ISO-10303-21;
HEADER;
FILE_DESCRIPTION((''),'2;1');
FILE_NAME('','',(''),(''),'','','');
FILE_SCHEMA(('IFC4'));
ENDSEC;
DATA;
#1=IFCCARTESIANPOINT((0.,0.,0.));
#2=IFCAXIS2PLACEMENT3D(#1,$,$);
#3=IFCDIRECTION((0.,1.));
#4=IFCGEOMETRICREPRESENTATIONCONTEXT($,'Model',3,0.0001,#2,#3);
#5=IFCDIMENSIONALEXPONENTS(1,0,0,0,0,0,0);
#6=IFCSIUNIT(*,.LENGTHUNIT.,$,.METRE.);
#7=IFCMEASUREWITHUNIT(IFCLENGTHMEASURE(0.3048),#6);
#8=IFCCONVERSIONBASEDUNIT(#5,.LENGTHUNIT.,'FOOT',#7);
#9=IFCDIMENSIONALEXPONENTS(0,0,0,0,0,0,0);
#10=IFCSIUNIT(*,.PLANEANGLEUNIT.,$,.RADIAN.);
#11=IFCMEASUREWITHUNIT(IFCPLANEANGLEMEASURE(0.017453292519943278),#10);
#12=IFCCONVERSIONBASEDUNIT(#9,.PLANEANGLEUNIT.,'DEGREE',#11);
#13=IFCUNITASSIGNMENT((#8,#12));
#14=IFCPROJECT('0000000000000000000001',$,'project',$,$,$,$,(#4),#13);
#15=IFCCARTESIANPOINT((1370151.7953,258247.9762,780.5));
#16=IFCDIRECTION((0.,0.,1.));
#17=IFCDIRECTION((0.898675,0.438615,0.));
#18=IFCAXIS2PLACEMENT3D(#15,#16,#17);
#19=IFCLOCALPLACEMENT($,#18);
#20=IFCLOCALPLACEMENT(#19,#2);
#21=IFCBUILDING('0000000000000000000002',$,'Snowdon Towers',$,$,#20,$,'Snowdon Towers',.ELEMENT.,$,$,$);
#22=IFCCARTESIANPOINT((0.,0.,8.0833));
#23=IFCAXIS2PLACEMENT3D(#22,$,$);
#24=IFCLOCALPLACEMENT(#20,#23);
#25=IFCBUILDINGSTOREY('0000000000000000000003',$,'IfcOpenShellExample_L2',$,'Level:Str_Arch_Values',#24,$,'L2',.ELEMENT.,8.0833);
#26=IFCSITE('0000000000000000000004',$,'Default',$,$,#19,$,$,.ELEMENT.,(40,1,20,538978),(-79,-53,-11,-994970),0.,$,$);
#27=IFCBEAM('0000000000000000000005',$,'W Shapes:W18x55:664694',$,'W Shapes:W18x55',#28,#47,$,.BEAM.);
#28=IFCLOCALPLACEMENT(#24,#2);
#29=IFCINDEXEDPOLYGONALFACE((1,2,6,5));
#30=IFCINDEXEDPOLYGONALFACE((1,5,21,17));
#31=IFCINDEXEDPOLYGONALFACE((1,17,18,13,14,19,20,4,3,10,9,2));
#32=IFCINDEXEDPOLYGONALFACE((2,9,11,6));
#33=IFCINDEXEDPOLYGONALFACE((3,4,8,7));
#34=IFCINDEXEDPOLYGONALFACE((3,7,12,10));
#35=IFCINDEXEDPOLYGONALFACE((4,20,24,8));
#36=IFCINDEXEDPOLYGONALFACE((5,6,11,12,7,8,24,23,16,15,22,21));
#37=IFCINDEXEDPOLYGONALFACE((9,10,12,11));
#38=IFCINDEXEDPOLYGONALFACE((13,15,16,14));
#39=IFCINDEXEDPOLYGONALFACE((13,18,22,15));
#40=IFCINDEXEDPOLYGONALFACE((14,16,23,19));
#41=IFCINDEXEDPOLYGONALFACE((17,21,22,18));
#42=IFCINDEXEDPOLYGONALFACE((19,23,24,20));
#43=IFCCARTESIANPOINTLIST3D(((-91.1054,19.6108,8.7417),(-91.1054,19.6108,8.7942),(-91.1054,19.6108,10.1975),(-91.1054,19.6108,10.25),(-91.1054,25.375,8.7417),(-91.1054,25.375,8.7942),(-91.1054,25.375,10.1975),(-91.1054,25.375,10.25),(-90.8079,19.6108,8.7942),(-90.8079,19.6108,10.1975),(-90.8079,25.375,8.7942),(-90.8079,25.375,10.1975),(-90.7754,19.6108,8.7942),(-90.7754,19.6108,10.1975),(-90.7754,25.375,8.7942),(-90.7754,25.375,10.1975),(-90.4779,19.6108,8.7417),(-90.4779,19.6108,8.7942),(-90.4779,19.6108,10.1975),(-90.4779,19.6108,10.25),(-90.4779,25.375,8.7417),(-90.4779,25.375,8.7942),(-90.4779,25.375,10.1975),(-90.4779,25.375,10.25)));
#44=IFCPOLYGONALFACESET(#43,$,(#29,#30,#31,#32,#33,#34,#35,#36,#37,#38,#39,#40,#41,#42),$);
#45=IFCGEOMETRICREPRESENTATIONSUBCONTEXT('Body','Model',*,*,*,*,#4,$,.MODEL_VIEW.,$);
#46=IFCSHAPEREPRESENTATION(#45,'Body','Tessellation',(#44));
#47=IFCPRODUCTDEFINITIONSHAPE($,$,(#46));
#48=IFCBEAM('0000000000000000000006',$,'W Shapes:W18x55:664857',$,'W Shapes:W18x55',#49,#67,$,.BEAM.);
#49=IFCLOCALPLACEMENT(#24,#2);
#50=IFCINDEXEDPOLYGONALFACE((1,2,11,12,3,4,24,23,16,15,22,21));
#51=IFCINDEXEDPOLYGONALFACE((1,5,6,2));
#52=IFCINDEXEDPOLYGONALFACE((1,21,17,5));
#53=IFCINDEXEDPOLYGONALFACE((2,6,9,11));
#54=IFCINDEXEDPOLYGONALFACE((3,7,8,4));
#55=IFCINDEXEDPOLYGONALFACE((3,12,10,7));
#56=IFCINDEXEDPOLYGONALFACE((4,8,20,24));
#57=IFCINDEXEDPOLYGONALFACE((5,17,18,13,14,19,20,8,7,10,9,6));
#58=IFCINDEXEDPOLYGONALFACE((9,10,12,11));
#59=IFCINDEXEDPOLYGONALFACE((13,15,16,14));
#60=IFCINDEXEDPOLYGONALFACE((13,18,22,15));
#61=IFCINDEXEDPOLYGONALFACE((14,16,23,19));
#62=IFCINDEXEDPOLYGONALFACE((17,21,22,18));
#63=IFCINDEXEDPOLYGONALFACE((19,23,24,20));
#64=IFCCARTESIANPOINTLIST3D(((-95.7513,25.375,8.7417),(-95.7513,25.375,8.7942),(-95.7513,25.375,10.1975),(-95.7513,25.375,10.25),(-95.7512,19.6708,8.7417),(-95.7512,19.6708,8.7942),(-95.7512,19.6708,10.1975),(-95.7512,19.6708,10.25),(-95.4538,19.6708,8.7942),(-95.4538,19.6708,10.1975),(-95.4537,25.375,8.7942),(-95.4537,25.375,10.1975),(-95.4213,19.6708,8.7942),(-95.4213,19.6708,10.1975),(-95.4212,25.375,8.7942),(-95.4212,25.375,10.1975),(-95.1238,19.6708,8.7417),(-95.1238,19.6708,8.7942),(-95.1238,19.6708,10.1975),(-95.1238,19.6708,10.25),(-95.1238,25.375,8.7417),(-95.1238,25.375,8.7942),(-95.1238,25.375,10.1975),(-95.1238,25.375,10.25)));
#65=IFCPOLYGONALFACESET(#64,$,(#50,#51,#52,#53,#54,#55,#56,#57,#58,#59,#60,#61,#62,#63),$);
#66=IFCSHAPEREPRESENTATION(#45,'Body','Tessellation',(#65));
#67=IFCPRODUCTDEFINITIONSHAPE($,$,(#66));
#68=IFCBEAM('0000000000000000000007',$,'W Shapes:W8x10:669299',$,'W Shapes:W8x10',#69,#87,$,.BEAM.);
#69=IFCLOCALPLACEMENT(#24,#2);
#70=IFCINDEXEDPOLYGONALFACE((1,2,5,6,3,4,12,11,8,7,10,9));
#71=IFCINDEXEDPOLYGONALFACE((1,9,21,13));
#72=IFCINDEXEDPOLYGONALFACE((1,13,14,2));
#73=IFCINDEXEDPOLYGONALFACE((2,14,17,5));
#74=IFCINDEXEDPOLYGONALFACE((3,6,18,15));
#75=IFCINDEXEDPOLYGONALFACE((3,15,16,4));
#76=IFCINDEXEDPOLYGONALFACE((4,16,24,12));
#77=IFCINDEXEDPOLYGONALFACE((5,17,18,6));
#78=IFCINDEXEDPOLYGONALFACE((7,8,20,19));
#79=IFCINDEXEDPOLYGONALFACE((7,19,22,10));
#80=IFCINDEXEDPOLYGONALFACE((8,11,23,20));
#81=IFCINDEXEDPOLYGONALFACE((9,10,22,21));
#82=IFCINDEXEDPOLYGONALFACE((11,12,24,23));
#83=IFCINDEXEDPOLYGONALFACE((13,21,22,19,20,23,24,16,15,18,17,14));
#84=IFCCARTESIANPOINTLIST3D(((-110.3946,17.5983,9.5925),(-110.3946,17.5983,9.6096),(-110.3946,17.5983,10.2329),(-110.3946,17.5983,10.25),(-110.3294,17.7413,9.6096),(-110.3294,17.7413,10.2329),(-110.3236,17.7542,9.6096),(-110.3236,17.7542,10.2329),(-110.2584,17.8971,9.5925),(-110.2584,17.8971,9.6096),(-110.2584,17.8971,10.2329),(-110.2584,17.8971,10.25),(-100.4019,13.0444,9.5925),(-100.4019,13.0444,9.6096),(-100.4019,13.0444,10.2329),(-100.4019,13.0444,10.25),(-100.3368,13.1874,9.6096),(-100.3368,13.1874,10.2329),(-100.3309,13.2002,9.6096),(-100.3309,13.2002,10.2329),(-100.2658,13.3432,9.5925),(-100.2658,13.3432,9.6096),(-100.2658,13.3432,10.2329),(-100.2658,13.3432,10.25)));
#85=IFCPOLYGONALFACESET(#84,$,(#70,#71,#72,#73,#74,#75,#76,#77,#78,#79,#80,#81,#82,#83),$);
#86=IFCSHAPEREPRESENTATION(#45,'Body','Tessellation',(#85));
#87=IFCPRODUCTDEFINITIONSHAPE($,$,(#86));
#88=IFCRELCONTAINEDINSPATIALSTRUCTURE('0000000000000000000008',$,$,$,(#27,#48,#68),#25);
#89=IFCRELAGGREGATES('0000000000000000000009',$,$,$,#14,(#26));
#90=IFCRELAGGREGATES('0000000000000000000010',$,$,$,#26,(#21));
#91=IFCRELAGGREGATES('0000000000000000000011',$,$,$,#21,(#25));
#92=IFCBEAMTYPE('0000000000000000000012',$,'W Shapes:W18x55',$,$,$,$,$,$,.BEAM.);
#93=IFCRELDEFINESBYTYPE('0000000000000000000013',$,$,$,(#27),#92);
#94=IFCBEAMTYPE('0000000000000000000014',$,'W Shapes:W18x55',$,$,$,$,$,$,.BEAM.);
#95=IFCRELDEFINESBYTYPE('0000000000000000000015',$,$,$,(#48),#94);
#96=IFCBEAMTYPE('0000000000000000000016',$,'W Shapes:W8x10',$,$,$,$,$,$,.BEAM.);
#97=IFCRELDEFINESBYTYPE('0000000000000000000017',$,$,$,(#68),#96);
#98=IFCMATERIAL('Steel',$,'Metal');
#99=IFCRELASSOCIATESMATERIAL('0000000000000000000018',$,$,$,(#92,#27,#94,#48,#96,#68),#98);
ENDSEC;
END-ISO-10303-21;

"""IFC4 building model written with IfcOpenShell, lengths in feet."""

from ifc_helpers import new_model, entity, si_unit, converted_unit, direction, frame, origin, place, context, subcontext, project, spatial, indexed_curve, outline, extrude, source, transform, mapped, material, type_object, type_shapes, element, save


model = new_model("IFC4")

# Units and contexts
model_context = context("Model", 3, precision=0.0001, world=origin(), true_north=direction((0.0, 1.0)))
body_context = subcontext(model_context, "Body", "Model", "MODEL_VIEW")
ifc_project = project(units=[converted_unit("LENGTHUNIT", "FOOT", entity("IfcLengthMeasure", 0.3048), si_unit("LENGTHUNIT", "METRE"), dimensions=[1, 0, 0, 0, 0, 0, 0]), converted_unit("PLANEANGLEUNIT", "DEGREE", entity("IfcPlaneAngleMeasure", 0.017453292519943278), si_unit("PLANEANGLEUNIT", "RADIAN"), dimensions=[0, 0, 0, 0, 0, 0, 0])], contexts=[model_context])

# Site, building, storey
site_placement = place(None, frame((1370151.7953, 258247.9762, 780.5), z_axis=(0.0, 0.0, 1.0), x_axis=(0.898675, 0.438615, 0.0)))
site = spatial("IfcSite", under=ifc_project, at=site_placement, Name="Default", CompositionType="ELEMENT", RefLatitude=(40, 1, 20, 538978), RefLongitude=(-79, -53, -11, -994970), RefElevation=0.0)
building_placement = place(site_placement, origin())
building = spatial("IfcBuilding", under=site, at=building_placement, Name="Snowdon Towers", LongName="Snowdon Towers", CompositionType="ELEMENT")
storey_placement = place(building_placement, frame((0.0, 0.0, 8.0833)))
storey = spatial("IfcBuildingStorey", under=building, at=storey_placement, Name="IfcOpenShellExample_L2", ObjectType="Level:Str_Arch_Values", LongName="L2", CompositionType="ELEMENT", Elevation=8.0833)

# Shared definitions
ifc_material = material(Name="Steel", Category="Metal")

# Beams
beam_type_1 = type_object("IfcBeamType", Name="W Shapes:W18x55", PredefinedType="BEAM", material=ifc_material)
shared_shape_1 = source(origin(), body_context, "Body", "SweptSolid", [
    extrude(outline(indexed_curve([(-0.3138, -0.7017), (-0.3138, -0.7542), (0.3138, -0.7542), (0.3138, -0.7017), (0.0162, -0.7017), (0.0162, 0.7017), (0.3138, 0.7017), (0.3138, 0.7542), (-0.3137, 0.7542), (-0.3137, 0.7017), (-0.0163, 0.7017), (-0.0163, -0.7017), (-0.3138, -0.7017)], self_intersect=False)), frame((-2.6737, 0.0, 0.0), z_axis=(-1.0, 0.0, 0.0), x_axis=(0.0, -1.0, 0.0)), (0.0, 0.0, -1.0), 5.7642),
])
type_shapes(beam_type_1, [shared_shape_1])
beam_1_placement = place(storey_placement, frame((-90.7917, 22.2846, 9.4958), z_axis=(0.0, 0.0, 1.0), x_axis=(0.0, 1.0, 0.0)))
element("IfcBeam", 1, at=beam_1_placement, inside=storey, type_object=beam_type_1, material=ifc_material, Name="W Shapes:W18x55:664694", ObjectType="W Shapes:W18x55", PredefinedType="BEAM", context=body_context, shape_type="MappedRepresentation", body=[
    mapped(shared_shape_1, transform((0.0, 0.0, 0.0), scale=1.0)),
])
beam_type_2 = type_object("IfcBeamType", Name="W Shapes:W18x55", PredefinedType="BEAM", material=ifc_material)
shared_shape_2 = source(origin(), body_context, "Body", "SweptSolid", [
    extrude(outline(indexed_curve([(-0.3138, -0.7017), (-0.3138, -0.7542), (0.3138, -0.7542), (0.3138, -0.7017), (0.0162, -0.7017), (0.0162, 0.7017), (0.3138, 0.7017), (0.3138, 0.7542), (-0.3137, 0.7542), (-0.3137, 0.7017), (-0.0163, 0.7017), (-0.0163, -0.7017), (-0.3138, -0.7017)], self_intersect=False)), frame((-2.6208, 0.0, 0.0), z_axis=(-1.0, 0.0, 0.0), x_axis=(0.0, -1.0, 0.0)), (0.0, 0.0, -1.0), 5.7042),
])
type_shapes(beam_type_2, [shared_shape_2])
beam_2_placement = place(storey_placement, frame((-95.4375, 22.2917, 9.4958), z_axis=(0.0, 0.0, 1.0), x_axis=(0.0, 1.0, 0.0)))
element("IfcBeam", 2, at=beam_2_placement, inside=storey, type_object=beam_type_2, material=ifc_material, Name="W Shapes:W18x55:664857", ObjectType="W Shapes:W18x55", PredefinedType="BEAM", context=body_context, shape_type="MappedRepresentation", body=[
    mapped(shared_shape_2, transform((0.0, 0.0, 0.0), scale=1.0)),
])
beam_type_3 = type_object("IfcBeamType", Name="W Shapes:W8x10", PredefinedType="BEAM", material=ifc_material)
shared_shape_3 = source(origin(), body_context, "Body", "SweptSolid", [
    extrude(outline(indexed_curve([(-0.1642, -0.3117), (-0.1642, -0.3288), (0.1642, -0.3288), (0.1642, -0.3117), (0.0071, -0.3117), (0.0071, 0.3117), (0.1642, 0.3117), (0.1642, 0.3287), (-0.1642, 0.3287), (-0.1642, 0.3117), (-0.0071, 0.3117), (-0.0071, -0.3117), (-0.1642, -0.3117)], self_intersect=False)), frame((-5.533, 0.0, 0.0), z_axis=(-1.0, 0.0, 0.0), x_axis=(0.0, -1.0, 0.0)), (0.0, 0.0, -1.0), 10.9814),
])
type_shapes(beam_type_3, [shared_shape_3])
beam_3_placement = place(storey_placement, frame((-105.2917, 15.4532, 9.9213), z_axis=(0.0, 0.0, 1.0), x_axis=(0.909961, -0.414693, 0.0)))
element("IfcBeam", 3, at=beam_3_placement, inside=storey, type_object=beam_type_3, material=ifc_material, Name="W Shapes:W8x10:669299", ObjectType="W Shapes:W8x10", PredefinedType="BEAM", context=body_context, shape_type="MappedRepresentation", body=[
    mapped(shared_shape_3, transform((0.0, 0.0, 0.0), scale=1.0)),
])

save(model, "model.ifc")
